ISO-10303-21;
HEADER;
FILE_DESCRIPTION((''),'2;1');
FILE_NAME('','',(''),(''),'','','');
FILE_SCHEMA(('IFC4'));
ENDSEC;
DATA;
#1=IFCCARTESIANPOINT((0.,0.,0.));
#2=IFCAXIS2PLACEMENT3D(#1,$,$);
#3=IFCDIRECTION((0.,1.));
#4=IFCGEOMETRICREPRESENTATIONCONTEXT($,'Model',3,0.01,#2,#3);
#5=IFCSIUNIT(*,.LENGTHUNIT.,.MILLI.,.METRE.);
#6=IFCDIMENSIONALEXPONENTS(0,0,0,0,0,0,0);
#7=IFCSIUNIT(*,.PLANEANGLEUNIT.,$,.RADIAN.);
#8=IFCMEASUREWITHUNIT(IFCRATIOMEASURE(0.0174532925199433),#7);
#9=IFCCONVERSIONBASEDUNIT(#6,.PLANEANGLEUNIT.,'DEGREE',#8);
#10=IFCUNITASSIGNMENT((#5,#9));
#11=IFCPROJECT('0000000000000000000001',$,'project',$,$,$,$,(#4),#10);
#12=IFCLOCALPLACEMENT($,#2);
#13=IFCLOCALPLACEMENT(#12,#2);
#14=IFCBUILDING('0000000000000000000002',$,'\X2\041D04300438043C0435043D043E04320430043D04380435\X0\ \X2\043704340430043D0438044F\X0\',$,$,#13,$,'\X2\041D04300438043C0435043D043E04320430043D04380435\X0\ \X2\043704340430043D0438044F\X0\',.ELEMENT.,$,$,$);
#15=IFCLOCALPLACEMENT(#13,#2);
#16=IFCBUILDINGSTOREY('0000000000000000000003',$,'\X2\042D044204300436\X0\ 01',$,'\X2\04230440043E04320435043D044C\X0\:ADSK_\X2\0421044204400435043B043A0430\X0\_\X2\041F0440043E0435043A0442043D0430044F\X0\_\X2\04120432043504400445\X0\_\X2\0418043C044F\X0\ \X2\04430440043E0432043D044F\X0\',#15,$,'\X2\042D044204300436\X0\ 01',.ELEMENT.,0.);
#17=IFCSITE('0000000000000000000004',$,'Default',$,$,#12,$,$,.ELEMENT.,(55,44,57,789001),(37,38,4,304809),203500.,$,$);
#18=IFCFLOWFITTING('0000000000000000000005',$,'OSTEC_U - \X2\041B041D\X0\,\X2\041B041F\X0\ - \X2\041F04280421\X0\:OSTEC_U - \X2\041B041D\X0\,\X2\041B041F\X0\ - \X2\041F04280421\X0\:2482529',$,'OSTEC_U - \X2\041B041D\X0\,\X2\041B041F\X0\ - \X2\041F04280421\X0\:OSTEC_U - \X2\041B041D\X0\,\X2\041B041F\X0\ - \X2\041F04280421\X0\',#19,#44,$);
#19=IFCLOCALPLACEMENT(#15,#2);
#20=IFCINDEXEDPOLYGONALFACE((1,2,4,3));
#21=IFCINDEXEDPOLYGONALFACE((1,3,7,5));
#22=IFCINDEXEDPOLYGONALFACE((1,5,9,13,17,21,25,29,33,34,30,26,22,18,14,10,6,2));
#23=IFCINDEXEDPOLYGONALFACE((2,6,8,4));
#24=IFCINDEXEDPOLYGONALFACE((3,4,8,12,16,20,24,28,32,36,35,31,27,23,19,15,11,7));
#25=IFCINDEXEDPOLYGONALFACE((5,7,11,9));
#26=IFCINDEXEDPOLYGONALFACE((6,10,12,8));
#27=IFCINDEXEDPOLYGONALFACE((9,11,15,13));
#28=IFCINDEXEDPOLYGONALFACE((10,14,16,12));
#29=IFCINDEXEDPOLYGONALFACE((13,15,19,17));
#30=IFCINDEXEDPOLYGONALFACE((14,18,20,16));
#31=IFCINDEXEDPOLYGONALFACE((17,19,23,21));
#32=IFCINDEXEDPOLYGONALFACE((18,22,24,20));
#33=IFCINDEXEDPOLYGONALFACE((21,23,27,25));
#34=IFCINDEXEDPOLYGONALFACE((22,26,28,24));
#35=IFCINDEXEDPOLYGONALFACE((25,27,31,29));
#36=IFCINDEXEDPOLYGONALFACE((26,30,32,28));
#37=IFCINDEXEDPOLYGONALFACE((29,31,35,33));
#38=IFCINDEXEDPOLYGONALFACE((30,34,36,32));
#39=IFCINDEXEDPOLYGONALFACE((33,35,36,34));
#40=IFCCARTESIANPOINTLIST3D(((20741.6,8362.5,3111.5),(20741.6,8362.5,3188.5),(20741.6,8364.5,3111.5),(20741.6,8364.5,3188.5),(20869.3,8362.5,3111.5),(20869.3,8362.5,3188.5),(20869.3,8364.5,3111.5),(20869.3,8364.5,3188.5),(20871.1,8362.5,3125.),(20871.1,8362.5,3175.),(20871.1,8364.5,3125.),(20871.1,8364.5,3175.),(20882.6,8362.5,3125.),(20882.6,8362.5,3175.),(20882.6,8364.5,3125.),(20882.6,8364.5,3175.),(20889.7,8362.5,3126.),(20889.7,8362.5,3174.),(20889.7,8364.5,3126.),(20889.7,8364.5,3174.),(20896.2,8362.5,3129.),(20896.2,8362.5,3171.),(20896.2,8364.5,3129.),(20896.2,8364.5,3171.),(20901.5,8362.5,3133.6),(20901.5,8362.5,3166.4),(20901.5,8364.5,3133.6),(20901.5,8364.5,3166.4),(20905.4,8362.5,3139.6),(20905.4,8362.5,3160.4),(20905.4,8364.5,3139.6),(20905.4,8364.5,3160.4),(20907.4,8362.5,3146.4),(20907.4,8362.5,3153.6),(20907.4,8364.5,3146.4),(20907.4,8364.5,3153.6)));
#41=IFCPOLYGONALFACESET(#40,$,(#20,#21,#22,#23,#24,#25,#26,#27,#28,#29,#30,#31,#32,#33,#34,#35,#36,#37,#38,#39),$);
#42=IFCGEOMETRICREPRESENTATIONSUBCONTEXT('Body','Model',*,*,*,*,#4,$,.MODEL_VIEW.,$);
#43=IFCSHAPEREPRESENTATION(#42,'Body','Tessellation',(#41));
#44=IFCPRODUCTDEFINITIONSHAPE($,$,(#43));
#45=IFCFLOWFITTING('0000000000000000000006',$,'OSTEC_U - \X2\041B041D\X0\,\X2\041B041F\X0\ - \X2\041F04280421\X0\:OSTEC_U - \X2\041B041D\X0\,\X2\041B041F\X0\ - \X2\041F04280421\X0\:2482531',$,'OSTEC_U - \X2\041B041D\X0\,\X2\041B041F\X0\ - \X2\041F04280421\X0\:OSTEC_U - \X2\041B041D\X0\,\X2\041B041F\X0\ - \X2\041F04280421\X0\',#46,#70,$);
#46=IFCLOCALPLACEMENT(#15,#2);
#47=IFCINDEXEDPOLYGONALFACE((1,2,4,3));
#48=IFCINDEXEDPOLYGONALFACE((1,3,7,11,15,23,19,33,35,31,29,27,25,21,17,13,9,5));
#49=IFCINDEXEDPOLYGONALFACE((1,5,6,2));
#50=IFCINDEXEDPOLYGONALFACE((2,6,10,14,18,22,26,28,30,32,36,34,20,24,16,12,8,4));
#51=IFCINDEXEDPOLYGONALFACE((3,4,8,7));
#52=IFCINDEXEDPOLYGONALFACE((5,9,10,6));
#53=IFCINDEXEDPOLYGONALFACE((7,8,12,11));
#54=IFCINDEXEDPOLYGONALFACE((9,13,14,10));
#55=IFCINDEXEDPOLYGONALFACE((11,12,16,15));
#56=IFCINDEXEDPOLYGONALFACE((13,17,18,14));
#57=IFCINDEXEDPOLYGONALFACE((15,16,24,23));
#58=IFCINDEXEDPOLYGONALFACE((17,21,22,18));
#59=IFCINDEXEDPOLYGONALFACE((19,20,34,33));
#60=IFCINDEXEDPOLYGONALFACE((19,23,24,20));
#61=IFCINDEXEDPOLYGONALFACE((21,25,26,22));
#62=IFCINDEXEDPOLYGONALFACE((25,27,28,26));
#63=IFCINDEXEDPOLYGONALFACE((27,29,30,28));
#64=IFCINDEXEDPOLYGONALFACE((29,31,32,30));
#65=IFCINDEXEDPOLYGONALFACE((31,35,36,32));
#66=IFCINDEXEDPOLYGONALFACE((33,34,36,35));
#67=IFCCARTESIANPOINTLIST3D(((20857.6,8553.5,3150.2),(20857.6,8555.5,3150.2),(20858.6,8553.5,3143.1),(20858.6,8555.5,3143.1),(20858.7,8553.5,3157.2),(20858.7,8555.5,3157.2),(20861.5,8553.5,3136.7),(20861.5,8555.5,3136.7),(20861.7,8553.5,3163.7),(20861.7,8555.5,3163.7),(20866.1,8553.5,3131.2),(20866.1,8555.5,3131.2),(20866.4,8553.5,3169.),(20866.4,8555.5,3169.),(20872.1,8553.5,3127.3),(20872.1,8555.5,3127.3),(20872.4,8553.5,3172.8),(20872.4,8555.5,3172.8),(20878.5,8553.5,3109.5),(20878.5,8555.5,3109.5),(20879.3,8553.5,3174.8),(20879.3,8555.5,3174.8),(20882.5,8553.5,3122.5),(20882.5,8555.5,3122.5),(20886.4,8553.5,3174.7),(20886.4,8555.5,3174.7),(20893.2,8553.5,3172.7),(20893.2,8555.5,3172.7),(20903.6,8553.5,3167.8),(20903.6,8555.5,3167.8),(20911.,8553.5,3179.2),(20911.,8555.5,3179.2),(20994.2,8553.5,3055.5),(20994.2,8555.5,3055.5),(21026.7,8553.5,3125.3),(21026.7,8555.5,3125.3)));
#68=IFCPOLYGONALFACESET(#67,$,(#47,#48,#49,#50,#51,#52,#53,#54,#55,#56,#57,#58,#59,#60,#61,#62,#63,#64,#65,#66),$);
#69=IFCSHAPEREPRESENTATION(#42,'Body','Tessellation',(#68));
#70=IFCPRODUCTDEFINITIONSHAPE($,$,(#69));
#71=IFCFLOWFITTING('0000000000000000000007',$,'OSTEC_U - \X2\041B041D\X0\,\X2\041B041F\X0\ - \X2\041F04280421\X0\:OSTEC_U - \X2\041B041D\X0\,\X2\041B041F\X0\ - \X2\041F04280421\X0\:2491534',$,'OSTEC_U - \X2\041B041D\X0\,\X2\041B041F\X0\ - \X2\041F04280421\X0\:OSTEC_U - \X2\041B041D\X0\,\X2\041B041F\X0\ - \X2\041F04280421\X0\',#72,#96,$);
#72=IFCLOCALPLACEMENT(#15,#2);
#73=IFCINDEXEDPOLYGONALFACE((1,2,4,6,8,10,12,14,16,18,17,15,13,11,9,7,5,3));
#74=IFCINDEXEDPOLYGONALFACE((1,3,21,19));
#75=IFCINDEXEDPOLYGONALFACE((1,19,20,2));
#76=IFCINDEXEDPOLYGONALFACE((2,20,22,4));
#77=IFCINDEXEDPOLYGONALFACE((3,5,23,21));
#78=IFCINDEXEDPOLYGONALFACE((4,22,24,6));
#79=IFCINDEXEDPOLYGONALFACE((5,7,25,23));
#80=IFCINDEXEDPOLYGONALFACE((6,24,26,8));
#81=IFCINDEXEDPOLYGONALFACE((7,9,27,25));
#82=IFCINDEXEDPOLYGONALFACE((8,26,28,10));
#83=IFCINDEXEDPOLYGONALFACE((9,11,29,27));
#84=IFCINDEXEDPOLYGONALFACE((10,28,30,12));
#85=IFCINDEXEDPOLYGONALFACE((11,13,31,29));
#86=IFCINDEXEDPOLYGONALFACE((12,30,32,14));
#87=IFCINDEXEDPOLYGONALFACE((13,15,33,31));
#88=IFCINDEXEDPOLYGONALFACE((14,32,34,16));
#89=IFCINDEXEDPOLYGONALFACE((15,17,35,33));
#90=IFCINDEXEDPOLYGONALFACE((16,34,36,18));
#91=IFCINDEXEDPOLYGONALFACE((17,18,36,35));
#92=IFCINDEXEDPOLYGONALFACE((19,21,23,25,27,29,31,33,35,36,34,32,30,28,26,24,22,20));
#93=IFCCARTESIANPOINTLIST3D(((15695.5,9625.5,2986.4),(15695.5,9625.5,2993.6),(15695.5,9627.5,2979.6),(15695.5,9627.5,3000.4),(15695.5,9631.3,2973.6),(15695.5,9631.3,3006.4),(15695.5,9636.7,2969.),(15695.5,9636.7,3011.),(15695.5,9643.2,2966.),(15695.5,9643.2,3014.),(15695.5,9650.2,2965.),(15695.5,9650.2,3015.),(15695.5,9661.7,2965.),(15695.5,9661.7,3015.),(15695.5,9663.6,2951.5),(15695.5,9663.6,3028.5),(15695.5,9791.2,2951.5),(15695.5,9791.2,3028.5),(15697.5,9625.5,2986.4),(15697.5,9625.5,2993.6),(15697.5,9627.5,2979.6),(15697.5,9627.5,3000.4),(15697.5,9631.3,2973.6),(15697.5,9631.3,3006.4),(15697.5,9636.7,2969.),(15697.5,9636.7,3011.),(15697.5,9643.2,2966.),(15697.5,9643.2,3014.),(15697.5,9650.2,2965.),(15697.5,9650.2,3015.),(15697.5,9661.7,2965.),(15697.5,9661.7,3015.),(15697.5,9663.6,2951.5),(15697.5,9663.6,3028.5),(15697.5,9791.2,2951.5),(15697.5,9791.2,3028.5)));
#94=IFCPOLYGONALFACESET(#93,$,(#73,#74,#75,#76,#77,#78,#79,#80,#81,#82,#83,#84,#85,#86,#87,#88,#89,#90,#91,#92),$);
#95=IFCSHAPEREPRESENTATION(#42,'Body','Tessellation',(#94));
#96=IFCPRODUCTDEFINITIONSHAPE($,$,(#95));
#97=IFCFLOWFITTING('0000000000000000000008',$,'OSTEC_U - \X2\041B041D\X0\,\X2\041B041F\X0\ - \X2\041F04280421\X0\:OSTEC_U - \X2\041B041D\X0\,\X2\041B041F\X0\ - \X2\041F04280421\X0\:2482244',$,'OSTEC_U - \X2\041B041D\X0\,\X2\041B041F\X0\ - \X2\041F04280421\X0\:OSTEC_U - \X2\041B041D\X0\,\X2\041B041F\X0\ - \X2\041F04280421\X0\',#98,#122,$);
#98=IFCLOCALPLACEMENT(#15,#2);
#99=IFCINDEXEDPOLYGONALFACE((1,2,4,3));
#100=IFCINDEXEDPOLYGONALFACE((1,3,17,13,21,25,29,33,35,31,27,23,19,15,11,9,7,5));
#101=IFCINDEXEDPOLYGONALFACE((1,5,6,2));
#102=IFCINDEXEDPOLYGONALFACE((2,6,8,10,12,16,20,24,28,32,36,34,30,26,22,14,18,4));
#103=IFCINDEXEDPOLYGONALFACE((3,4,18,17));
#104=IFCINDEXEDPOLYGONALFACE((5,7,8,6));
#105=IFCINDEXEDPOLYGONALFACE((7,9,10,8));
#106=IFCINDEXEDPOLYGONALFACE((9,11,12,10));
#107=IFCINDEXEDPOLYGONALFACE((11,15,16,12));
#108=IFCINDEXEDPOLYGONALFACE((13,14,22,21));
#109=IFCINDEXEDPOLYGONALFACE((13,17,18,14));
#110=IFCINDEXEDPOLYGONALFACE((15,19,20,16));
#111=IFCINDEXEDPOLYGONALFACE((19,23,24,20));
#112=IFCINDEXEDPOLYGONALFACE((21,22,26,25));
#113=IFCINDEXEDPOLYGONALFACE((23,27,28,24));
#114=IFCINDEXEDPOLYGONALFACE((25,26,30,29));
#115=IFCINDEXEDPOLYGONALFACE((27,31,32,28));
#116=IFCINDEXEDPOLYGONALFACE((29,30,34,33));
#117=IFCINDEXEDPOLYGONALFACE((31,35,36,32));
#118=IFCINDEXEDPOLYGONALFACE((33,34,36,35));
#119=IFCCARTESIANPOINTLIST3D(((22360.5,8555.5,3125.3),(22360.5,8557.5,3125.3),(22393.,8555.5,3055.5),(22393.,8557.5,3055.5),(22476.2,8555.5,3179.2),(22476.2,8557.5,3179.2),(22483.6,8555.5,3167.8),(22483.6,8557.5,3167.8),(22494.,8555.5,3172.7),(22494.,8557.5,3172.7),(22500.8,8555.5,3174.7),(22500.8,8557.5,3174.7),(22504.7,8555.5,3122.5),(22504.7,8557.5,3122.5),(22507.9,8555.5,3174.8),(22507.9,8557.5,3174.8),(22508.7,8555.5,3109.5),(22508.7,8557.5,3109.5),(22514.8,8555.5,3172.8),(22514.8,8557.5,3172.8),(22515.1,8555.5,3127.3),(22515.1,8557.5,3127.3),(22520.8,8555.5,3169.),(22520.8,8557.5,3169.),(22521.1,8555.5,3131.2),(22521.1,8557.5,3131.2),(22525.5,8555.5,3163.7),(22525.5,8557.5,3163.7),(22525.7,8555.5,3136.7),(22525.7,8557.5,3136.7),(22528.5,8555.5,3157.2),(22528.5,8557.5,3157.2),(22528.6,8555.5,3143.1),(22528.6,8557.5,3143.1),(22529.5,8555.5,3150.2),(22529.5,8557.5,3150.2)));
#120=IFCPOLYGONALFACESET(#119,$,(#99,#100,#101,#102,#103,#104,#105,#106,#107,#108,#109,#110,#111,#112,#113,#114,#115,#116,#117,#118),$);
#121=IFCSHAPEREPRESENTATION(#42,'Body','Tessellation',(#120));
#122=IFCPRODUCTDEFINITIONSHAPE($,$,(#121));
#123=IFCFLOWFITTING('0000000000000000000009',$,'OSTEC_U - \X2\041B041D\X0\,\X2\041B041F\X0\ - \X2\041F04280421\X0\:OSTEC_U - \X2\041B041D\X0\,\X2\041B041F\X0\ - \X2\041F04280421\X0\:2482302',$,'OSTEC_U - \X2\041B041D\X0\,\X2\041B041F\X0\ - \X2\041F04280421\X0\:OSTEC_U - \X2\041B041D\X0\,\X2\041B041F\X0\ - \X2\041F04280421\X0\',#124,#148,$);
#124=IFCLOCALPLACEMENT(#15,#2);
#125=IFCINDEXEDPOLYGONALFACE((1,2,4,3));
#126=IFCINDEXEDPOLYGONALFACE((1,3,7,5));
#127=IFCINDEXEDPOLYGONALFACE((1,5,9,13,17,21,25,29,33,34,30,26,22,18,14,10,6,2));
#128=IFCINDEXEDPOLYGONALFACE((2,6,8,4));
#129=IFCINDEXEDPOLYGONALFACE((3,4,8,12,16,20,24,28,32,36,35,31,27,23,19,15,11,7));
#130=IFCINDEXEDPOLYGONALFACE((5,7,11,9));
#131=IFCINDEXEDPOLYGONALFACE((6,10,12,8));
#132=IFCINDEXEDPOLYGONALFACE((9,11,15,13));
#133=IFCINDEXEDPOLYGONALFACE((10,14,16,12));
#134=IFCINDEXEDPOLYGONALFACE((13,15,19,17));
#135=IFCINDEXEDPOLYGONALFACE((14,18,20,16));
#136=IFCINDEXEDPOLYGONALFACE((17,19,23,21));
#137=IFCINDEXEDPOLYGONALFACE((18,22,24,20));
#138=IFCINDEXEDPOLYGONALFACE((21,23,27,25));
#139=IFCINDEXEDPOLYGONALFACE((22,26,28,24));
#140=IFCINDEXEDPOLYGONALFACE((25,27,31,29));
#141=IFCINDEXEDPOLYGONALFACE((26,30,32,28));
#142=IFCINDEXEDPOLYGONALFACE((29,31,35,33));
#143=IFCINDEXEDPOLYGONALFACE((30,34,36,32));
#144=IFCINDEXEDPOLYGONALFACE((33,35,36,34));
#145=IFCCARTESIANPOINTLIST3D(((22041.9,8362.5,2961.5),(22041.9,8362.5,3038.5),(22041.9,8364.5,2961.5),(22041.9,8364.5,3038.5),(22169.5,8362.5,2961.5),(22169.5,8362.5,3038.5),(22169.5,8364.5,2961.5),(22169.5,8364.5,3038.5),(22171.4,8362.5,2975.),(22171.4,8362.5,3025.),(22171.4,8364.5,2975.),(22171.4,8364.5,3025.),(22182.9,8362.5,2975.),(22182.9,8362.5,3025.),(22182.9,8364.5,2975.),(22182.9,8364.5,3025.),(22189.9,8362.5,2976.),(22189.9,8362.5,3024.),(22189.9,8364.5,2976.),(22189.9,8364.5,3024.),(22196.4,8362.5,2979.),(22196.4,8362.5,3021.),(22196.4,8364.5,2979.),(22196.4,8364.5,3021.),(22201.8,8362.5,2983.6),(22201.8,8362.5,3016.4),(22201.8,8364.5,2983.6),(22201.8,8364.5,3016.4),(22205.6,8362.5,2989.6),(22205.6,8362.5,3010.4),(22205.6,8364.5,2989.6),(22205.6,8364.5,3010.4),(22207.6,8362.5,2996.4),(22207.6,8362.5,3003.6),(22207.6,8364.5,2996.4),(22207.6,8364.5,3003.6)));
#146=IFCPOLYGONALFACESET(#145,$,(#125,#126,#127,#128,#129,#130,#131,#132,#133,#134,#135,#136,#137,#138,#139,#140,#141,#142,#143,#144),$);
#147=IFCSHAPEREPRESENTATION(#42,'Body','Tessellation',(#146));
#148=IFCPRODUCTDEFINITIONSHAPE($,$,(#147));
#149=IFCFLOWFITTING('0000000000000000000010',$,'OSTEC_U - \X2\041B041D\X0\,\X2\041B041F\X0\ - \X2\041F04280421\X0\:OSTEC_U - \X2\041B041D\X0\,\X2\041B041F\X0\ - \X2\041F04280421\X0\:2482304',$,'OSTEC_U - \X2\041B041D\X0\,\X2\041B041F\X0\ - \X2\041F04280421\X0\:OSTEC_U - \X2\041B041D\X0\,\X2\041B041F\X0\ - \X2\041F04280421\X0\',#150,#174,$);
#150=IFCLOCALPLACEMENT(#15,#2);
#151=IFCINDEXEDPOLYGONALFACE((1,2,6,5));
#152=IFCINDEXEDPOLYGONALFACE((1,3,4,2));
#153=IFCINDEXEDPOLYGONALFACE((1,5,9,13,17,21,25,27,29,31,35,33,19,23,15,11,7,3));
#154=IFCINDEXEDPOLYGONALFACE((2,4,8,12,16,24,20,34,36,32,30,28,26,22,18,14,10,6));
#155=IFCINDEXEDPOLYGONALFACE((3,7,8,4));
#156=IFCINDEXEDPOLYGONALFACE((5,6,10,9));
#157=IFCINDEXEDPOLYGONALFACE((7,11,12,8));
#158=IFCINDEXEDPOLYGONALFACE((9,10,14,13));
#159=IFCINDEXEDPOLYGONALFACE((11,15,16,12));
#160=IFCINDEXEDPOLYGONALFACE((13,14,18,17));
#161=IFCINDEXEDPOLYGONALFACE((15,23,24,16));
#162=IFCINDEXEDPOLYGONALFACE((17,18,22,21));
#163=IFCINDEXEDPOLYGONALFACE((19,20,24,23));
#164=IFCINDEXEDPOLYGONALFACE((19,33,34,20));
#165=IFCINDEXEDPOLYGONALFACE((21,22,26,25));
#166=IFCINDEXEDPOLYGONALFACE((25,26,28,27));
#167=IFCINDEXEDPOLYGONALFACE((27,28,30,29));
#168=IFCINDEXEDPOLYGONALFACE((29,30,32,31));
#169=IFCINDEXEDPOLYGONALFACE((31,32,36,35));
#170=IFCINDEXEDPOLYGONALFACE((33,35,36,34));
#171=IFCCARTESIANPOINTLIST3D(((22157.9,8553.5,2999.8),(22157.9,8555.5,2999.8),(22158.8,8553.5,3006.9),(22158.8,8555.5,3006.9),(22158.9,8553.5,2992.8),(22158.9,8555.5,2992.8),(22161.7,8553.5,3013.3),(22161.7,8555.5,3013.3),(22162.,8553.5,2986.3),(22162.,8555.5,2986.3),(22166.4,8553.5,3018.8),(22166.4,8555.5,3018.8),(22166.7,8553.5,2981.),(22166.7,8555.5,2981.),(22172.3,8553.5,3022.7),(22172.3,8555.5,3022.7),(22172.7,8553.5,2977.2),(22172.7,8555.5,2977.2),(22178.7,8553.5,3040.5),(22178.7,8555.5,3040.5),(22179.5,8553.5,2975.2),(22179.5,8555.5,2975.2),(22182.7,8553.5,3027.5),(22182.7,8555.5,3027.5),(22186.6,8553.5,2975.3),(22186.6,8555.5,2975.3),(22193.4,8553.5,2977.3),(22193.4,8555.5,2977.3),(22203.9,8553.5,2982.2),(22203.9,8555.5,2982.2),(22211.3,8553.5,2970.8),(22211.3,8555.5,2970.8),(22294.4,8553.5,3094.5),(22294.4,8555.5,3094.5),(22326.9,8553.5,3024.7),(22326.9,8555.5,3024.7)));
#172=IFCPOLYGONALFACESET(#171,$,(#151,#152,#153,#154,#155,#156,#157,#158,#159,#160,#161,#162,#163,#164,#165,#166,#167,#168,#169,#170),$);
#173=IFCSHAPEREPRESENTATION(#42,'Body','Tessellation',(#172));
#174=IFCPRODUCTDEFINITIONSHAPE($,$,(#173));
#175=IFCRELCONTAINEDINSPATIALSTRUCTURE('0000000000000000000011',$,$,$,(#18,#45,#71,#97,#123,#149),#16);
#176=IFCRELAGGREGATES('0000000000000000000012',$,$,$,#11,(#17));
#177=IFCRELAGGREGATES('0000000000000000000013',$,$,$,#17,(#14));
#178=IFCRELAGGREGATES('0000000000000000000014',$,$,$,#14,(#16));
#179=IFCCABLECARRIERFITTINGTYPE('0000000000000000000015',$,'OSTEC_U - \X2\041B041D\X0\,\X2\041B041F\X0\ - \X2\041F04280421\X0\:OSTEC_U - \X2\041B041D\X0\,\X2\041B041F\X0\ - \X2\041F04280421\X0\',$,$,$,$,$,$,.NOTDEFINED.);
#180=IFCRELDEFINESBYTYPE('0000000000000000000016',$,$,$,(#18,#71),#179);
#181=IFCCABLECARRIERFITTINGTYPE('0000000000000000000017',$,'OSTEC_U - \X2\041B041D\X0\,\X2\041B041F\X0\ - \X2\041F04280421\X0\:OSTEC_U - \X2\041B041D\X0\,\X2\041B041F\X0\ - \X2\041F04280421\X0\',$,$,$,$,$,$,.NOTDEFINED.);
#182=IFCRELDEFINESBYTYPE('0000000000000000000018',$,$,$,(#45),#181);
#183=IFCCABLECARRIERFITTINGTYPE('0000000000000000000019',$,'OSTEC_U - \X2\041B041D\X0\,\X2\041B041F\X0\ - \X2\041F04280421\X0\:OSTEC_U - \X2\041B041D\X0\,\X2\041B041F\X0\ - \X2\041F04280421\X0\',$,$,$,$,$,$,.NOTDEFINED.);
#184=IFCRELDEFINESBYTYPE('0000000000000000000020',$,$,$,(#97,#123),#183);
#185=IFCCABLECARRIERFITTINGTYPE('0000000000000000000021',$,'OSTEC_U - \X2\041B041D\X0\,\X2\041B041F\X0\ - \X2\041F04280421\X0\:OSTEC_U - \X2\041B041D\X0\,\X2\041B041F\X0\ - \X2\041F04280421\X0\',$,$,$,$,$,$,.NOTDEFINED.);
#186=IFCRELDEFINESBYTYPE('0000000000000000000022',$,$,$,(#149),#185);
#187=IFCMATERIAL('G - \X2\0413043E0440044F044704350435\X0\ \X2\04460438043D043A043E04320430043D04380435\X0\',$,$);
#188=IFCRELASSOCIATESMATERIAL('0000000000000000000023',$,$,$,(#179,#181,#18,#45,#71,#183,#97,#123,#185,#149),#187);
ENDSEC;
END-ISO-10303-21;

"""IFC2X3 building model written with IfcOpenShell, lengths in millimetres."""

from ifc_helpers import new_model, entity, si_unit, converted_unit, direction, frame, frame_2d, origin, place, context, subcontext, project, spatial, polyline, circle_curve, parameter, trimmed, segment, composite_curve, outline, extrude, source, transform, mapped, material, type_object, type_shapes, element, save


model = new_model("IFC2X3")

# Units and contexts
model_context = context("Model", 3, precision=0.01, world=origin(), true_north=direction((0.0, 1.0)))
body_context = subcontext(model_context, "Body", "Model", "MODEL_VIEW")
ifc_project = project(units=[si_unit("LENGTHUNIT", "METRE", prefix="MILLI"), converted_unit("PLANEANGLEUNIT", "DEGREE", entity("IfcRatioMeasure", 0.0174532925199433), si_unit("PLANEANGLEUNIT", "RADIAN"), dimensions=[0, 0, 0, 0, 0, 0, 0])], contexts=[model_context])

# Site, building, storey
site_placement = place(None, origin())
site = spatial("IfcSite", under=ifc_project, at=site_placement, Name="Default", CompositionType="ELEMENT", RefLatitude=(55, 44, 57, 789001), RefLongitude=(37, 38, 4, 304809), RefElevation=203500.0)
building_placement = place(site_placement, origin())
building = spatial("IfcBuilding", under=site, at=building_placement, Name="Наименование здания", LongName="Наименование здания", CompositionType="ELEMENT")
storey_placement = place(building_placement, origin())
storey = spatial("IfcBuildingStorey", under=building, at=storey_placement, Name="Этаж 01", ObjectType="Уровень:ADSK_Стрелка_Проектная_Вверх_Имя уровня", LongName="Этаж 01", CompositionType="ELEMENT", Elevation=0.0)

# Flow fittings
ifc_material = material(Name="G - Горячее цинкование")
cable_carrier_fitting_type_1 = type_object("IfcCableCarrierFittingType", Name="OSTEC_U - ЛН,ЛП - ПШС:OSTEC_U - ЛН,ЛП - ПШС", PredefinedType="NOTDEFINED", material=ifc_material)
shared_shape_1 = source(origin(), body_context, "Body", "SweptSolid", [
    extrude(outline(composite_curve([segment(trimmed(circle_curve(frame_2d((-41.5, 0.0), x_axis=(1.0, 0.0)), 25.0), [parameter(90.0)], [parameter(270.0)], True, "PARAMETER"), True, "CONTINUOUS"), segment(polyline([(-41.5, -25.0), (-30.0, -25.0)]), True, "CONTINUOUS"), segment(polyline([(-30.0, -25.0), (-28.1, -38.5)]), True, "CONTINUOUS"), segment(polyline([(-28.1, -38.5), (99.5, -38.5)]), True, "CONTINUOUS"), segment(polyline([(99.5, -38.5), (99.5, 38.5)]), True, "CONTINUOUS"), segment(polyline([(99.5, 38.5), (-28.1, 38.5)]), True, "CONTINUOUS"), segment(polyline([(-28.1, 38.5), (-30.0, 25.0)]), True, "CONTINUOUS"), segment(polyline([(-30.0, 25.0), (-41.5, 25.0)]), True, "CONTINUOUS")], self_intersect=False)), frame((41.5, 0.0, 0.0), z_axis=(0.0, 0.0, -1.0), x_axis=(1.0, 0.0, 0.0)), (0.0, 0.0, -1.0), 2.0),
])
type_shapes(cable_carrier_fitting_type_1, [shared_shape_1])
cable_carrier_fitting_type_2 = type_object("IfcCableCarrierFittingType", Name="OSTEC_U - ЛН,ЛП - ПШС:OSTEC_U - ЛН,ЛП - ПШС", PredefinedType="NOTDEFINED", material=ifc_material)
type_shapes(cable_carrier_fitting_type_2, [shared_shape_1])
flow_fitting_1_placement = place(storey_placement, frame((20882.6, 8364.5, 3150.0), z_axis=(0.0, -1.0, 0.0), x_axis=(-1.0, 0.0, 0.0)))
element("IfcFlowFitting", 1, at=flow_fitting_1_placement, inside=storey, type_object=cable_carrier_fitting_type_1, material=ifc_material, Name="OSTEC_U - ЛН,ЛП - ПШС:OSTEC_U - ЛН,ЛП - ПШС:2482529", ObjectType="OSTEC_U - ЛН,ЛП - ПШС:OSTEC_U - ЛН,ЛП - ПШС", context=body_context, shape_type="MappedRepresentation", body=[
    mapped(shared_shape_1, transform((0.0, 0.0, 0.0), scale=1.0)),
])
flow_fitting_2_placement = place(storey_placement, frame((20882.6, 8553.5, 3150.0), z_axis=(0.0, 1.0, 0.0), x_axis=(0.906308, 0.0, -0.422618)))
element("IfcFlowFitting", 2, at=flow_fitting_2_placement, inside=storey, type_object=cable_carrier_fitting_type_2, material=ifc_material, Name="OSTEC_U - ЛН,ЛП - ПШС:OSTEC_U - ЛН,ЛП - ПШС:2482531", ObjectType="OSTEC_U - ЛН,ЛП - ПШС:OSTEC_U - ЛН,ЛП - ПШС", context=body_context, shape_type="MappedRepresentation", body=[
    mapped(shared_shape_1, transform((0.0, 0.0, 0.0), scale=1.0)),
])
flow_fitting_3_placement = place(storey_placement, frame((15695.5, 9650.2, 2990.0), z_axis=(1.0, 0.0, 0.0), x_axis=(0.0, 1.0, 0.0)))
element("IfcFlowFitting", 3, at=flow_fitting_3_placement, inside=storey, type_object=cable_carrier_fitting_type_1, material=ifc_material, Name="OSTEC_U - ЛН,ЛП - ПШС:OSTEC_U - ЛН,ЛП - ПШС:2491534", ObjectType="OSTEC_U - ЛН,ЛП - ПШС:OSTEC_U - ЛН,ЛП - ПШС", context=body_context, shape_type="MappedRepresentation", body=[
    mapped(shared_shape_1, transform((0.0, 0.0, 0.0), scale=1.0)),
])
cable_carrier_fitting_type_3 = type_object("IfcCableCarrierFittingType", Name="OSTEC_U - ЛН,ЛП - ПШС:OSTEC_U - ЛН,ЛП - ПШС", PredefinedType="NOTDEFINED", material=ifc_material)
shared_shape_2 = source(origin(), body_context, "Body", "SweptSolid", [
    extrude(outline(composite_curve([segment(trimmed(circle_curve(frame_2d((-41.5, 0.0), x_axis=(1.0, 0.0)), 25.0), [parameter(90.0)], [parameter(270.0)], True, "PARAMETER"), True, "CONTINUOUS"), segment(polyline([(-41.5, -25.0), (-30.0, -25.0)]), True, "CONTINUOUS"), segment(polyline([(-30.0, -25.0), (-28.1, -38.5)]), True, "CONTINUOUS"), segment(polyline([(-28.1, -38.5), (99.5, -38.5)]), True, "CONTINUOUS"), segment(polyline([(99.5, -38.5), (99.5, 38.5)]), True, "CONTINUOUS"), segment(polyline([(99.5, 38.5), (-28.1, 38.5)]), True, "CONTINUOUS"), segment(polyline([(-28.1, 38.5), (-30.0, 25.0)]), True, "CONTINUOUS"), segment(polyline([(-30.0, 25.0), (-41.5, 25.0)]), True, "CONTINUOUS")], self_intersect=False)), frame((41.5, 0.0, 0.0)), (0.0, 0.0, 1.0), 2.0),
])
type_shapes(cable_carrier_fitting_type_3, [shared_shape_2])
for number, where, z_axis, x_axis, name in (
    (4, (22504.5, 8555.5, 3150.0), (0.0, 1.0, 0.0), (-0.906308, 0.0, -0.422618), "OSTEC_U - ЛН,ЛП - ПШС:OSTEC_U - ЛН,ЛП - ПШС:2482244"),
    (5, (22182.9, 8364.5, 3000.0), (0.0, -1.0, 0.0), (-1.0, 0.0, 0.0), "OSTEC_U - ЛН,ЛП - ПШС:OSTEC_U - ЛН,ЛП - ПШС:2482302"),
):
    element("IfcFlowFitting", number, at=place(storey_placement, frame(where, z_axis=z_axis, x_axis=x_axis)), inside=storey, type_object=cable_carrier_fitting_type_3, material=ifc_material, Name=name, ObjectType="OSTEC_U - ЛН,ЛП - ПШС:OSTEC_U - ЛН,ЛП - ПШС", context=body_context, shape_type="MappedRepresentation", body=[
        mapped(shared_shape_2, transform((0.0, 0.0, 0.0), scale=1.0)),
    ])
cable_carrier_fitting_type_4 = type_object("IfcCableCarrierFittingType", Name="OSTEC_U - ЛН,ЛП - ПШС:OSTEC_U - ЛН,ЛП - ПШС", PredefinedType="NOTDEFINED", material=ifc_material)
type_shapes(cable_carrier_fitting_type_4, [shared_shape_2])
flow_fitting_4_placement = place(storey_placement, frame((22182.9, 8553.5, 3000.0), z_axis=(0.0, 1.0, 0.0), x_axis=(0.906308, 0.0, 0.422618)))
element("IfcFlowFitting", 6, at=flow_fitting_4_placement, inside=storey, type_object=cable_carrier_fitting_type_4, material=ifc_material, Name="OSTEC_U - ЛН,ЛП - ПШС:OSTEC_U - ЛН,ЛП - ПШС:2482304", ObjectType="OSTEC_U - ЛН,ЛП - ПШС:OSTEC_U - ЛН,ЛП - ПШС", context=body_context, shape_type="MappedRepresentation", body=[
    mapped(shared_shape_2, transform((0.0, 0.0, 0.0), scale=1.0)),
])

save(model, "model.ifc")
